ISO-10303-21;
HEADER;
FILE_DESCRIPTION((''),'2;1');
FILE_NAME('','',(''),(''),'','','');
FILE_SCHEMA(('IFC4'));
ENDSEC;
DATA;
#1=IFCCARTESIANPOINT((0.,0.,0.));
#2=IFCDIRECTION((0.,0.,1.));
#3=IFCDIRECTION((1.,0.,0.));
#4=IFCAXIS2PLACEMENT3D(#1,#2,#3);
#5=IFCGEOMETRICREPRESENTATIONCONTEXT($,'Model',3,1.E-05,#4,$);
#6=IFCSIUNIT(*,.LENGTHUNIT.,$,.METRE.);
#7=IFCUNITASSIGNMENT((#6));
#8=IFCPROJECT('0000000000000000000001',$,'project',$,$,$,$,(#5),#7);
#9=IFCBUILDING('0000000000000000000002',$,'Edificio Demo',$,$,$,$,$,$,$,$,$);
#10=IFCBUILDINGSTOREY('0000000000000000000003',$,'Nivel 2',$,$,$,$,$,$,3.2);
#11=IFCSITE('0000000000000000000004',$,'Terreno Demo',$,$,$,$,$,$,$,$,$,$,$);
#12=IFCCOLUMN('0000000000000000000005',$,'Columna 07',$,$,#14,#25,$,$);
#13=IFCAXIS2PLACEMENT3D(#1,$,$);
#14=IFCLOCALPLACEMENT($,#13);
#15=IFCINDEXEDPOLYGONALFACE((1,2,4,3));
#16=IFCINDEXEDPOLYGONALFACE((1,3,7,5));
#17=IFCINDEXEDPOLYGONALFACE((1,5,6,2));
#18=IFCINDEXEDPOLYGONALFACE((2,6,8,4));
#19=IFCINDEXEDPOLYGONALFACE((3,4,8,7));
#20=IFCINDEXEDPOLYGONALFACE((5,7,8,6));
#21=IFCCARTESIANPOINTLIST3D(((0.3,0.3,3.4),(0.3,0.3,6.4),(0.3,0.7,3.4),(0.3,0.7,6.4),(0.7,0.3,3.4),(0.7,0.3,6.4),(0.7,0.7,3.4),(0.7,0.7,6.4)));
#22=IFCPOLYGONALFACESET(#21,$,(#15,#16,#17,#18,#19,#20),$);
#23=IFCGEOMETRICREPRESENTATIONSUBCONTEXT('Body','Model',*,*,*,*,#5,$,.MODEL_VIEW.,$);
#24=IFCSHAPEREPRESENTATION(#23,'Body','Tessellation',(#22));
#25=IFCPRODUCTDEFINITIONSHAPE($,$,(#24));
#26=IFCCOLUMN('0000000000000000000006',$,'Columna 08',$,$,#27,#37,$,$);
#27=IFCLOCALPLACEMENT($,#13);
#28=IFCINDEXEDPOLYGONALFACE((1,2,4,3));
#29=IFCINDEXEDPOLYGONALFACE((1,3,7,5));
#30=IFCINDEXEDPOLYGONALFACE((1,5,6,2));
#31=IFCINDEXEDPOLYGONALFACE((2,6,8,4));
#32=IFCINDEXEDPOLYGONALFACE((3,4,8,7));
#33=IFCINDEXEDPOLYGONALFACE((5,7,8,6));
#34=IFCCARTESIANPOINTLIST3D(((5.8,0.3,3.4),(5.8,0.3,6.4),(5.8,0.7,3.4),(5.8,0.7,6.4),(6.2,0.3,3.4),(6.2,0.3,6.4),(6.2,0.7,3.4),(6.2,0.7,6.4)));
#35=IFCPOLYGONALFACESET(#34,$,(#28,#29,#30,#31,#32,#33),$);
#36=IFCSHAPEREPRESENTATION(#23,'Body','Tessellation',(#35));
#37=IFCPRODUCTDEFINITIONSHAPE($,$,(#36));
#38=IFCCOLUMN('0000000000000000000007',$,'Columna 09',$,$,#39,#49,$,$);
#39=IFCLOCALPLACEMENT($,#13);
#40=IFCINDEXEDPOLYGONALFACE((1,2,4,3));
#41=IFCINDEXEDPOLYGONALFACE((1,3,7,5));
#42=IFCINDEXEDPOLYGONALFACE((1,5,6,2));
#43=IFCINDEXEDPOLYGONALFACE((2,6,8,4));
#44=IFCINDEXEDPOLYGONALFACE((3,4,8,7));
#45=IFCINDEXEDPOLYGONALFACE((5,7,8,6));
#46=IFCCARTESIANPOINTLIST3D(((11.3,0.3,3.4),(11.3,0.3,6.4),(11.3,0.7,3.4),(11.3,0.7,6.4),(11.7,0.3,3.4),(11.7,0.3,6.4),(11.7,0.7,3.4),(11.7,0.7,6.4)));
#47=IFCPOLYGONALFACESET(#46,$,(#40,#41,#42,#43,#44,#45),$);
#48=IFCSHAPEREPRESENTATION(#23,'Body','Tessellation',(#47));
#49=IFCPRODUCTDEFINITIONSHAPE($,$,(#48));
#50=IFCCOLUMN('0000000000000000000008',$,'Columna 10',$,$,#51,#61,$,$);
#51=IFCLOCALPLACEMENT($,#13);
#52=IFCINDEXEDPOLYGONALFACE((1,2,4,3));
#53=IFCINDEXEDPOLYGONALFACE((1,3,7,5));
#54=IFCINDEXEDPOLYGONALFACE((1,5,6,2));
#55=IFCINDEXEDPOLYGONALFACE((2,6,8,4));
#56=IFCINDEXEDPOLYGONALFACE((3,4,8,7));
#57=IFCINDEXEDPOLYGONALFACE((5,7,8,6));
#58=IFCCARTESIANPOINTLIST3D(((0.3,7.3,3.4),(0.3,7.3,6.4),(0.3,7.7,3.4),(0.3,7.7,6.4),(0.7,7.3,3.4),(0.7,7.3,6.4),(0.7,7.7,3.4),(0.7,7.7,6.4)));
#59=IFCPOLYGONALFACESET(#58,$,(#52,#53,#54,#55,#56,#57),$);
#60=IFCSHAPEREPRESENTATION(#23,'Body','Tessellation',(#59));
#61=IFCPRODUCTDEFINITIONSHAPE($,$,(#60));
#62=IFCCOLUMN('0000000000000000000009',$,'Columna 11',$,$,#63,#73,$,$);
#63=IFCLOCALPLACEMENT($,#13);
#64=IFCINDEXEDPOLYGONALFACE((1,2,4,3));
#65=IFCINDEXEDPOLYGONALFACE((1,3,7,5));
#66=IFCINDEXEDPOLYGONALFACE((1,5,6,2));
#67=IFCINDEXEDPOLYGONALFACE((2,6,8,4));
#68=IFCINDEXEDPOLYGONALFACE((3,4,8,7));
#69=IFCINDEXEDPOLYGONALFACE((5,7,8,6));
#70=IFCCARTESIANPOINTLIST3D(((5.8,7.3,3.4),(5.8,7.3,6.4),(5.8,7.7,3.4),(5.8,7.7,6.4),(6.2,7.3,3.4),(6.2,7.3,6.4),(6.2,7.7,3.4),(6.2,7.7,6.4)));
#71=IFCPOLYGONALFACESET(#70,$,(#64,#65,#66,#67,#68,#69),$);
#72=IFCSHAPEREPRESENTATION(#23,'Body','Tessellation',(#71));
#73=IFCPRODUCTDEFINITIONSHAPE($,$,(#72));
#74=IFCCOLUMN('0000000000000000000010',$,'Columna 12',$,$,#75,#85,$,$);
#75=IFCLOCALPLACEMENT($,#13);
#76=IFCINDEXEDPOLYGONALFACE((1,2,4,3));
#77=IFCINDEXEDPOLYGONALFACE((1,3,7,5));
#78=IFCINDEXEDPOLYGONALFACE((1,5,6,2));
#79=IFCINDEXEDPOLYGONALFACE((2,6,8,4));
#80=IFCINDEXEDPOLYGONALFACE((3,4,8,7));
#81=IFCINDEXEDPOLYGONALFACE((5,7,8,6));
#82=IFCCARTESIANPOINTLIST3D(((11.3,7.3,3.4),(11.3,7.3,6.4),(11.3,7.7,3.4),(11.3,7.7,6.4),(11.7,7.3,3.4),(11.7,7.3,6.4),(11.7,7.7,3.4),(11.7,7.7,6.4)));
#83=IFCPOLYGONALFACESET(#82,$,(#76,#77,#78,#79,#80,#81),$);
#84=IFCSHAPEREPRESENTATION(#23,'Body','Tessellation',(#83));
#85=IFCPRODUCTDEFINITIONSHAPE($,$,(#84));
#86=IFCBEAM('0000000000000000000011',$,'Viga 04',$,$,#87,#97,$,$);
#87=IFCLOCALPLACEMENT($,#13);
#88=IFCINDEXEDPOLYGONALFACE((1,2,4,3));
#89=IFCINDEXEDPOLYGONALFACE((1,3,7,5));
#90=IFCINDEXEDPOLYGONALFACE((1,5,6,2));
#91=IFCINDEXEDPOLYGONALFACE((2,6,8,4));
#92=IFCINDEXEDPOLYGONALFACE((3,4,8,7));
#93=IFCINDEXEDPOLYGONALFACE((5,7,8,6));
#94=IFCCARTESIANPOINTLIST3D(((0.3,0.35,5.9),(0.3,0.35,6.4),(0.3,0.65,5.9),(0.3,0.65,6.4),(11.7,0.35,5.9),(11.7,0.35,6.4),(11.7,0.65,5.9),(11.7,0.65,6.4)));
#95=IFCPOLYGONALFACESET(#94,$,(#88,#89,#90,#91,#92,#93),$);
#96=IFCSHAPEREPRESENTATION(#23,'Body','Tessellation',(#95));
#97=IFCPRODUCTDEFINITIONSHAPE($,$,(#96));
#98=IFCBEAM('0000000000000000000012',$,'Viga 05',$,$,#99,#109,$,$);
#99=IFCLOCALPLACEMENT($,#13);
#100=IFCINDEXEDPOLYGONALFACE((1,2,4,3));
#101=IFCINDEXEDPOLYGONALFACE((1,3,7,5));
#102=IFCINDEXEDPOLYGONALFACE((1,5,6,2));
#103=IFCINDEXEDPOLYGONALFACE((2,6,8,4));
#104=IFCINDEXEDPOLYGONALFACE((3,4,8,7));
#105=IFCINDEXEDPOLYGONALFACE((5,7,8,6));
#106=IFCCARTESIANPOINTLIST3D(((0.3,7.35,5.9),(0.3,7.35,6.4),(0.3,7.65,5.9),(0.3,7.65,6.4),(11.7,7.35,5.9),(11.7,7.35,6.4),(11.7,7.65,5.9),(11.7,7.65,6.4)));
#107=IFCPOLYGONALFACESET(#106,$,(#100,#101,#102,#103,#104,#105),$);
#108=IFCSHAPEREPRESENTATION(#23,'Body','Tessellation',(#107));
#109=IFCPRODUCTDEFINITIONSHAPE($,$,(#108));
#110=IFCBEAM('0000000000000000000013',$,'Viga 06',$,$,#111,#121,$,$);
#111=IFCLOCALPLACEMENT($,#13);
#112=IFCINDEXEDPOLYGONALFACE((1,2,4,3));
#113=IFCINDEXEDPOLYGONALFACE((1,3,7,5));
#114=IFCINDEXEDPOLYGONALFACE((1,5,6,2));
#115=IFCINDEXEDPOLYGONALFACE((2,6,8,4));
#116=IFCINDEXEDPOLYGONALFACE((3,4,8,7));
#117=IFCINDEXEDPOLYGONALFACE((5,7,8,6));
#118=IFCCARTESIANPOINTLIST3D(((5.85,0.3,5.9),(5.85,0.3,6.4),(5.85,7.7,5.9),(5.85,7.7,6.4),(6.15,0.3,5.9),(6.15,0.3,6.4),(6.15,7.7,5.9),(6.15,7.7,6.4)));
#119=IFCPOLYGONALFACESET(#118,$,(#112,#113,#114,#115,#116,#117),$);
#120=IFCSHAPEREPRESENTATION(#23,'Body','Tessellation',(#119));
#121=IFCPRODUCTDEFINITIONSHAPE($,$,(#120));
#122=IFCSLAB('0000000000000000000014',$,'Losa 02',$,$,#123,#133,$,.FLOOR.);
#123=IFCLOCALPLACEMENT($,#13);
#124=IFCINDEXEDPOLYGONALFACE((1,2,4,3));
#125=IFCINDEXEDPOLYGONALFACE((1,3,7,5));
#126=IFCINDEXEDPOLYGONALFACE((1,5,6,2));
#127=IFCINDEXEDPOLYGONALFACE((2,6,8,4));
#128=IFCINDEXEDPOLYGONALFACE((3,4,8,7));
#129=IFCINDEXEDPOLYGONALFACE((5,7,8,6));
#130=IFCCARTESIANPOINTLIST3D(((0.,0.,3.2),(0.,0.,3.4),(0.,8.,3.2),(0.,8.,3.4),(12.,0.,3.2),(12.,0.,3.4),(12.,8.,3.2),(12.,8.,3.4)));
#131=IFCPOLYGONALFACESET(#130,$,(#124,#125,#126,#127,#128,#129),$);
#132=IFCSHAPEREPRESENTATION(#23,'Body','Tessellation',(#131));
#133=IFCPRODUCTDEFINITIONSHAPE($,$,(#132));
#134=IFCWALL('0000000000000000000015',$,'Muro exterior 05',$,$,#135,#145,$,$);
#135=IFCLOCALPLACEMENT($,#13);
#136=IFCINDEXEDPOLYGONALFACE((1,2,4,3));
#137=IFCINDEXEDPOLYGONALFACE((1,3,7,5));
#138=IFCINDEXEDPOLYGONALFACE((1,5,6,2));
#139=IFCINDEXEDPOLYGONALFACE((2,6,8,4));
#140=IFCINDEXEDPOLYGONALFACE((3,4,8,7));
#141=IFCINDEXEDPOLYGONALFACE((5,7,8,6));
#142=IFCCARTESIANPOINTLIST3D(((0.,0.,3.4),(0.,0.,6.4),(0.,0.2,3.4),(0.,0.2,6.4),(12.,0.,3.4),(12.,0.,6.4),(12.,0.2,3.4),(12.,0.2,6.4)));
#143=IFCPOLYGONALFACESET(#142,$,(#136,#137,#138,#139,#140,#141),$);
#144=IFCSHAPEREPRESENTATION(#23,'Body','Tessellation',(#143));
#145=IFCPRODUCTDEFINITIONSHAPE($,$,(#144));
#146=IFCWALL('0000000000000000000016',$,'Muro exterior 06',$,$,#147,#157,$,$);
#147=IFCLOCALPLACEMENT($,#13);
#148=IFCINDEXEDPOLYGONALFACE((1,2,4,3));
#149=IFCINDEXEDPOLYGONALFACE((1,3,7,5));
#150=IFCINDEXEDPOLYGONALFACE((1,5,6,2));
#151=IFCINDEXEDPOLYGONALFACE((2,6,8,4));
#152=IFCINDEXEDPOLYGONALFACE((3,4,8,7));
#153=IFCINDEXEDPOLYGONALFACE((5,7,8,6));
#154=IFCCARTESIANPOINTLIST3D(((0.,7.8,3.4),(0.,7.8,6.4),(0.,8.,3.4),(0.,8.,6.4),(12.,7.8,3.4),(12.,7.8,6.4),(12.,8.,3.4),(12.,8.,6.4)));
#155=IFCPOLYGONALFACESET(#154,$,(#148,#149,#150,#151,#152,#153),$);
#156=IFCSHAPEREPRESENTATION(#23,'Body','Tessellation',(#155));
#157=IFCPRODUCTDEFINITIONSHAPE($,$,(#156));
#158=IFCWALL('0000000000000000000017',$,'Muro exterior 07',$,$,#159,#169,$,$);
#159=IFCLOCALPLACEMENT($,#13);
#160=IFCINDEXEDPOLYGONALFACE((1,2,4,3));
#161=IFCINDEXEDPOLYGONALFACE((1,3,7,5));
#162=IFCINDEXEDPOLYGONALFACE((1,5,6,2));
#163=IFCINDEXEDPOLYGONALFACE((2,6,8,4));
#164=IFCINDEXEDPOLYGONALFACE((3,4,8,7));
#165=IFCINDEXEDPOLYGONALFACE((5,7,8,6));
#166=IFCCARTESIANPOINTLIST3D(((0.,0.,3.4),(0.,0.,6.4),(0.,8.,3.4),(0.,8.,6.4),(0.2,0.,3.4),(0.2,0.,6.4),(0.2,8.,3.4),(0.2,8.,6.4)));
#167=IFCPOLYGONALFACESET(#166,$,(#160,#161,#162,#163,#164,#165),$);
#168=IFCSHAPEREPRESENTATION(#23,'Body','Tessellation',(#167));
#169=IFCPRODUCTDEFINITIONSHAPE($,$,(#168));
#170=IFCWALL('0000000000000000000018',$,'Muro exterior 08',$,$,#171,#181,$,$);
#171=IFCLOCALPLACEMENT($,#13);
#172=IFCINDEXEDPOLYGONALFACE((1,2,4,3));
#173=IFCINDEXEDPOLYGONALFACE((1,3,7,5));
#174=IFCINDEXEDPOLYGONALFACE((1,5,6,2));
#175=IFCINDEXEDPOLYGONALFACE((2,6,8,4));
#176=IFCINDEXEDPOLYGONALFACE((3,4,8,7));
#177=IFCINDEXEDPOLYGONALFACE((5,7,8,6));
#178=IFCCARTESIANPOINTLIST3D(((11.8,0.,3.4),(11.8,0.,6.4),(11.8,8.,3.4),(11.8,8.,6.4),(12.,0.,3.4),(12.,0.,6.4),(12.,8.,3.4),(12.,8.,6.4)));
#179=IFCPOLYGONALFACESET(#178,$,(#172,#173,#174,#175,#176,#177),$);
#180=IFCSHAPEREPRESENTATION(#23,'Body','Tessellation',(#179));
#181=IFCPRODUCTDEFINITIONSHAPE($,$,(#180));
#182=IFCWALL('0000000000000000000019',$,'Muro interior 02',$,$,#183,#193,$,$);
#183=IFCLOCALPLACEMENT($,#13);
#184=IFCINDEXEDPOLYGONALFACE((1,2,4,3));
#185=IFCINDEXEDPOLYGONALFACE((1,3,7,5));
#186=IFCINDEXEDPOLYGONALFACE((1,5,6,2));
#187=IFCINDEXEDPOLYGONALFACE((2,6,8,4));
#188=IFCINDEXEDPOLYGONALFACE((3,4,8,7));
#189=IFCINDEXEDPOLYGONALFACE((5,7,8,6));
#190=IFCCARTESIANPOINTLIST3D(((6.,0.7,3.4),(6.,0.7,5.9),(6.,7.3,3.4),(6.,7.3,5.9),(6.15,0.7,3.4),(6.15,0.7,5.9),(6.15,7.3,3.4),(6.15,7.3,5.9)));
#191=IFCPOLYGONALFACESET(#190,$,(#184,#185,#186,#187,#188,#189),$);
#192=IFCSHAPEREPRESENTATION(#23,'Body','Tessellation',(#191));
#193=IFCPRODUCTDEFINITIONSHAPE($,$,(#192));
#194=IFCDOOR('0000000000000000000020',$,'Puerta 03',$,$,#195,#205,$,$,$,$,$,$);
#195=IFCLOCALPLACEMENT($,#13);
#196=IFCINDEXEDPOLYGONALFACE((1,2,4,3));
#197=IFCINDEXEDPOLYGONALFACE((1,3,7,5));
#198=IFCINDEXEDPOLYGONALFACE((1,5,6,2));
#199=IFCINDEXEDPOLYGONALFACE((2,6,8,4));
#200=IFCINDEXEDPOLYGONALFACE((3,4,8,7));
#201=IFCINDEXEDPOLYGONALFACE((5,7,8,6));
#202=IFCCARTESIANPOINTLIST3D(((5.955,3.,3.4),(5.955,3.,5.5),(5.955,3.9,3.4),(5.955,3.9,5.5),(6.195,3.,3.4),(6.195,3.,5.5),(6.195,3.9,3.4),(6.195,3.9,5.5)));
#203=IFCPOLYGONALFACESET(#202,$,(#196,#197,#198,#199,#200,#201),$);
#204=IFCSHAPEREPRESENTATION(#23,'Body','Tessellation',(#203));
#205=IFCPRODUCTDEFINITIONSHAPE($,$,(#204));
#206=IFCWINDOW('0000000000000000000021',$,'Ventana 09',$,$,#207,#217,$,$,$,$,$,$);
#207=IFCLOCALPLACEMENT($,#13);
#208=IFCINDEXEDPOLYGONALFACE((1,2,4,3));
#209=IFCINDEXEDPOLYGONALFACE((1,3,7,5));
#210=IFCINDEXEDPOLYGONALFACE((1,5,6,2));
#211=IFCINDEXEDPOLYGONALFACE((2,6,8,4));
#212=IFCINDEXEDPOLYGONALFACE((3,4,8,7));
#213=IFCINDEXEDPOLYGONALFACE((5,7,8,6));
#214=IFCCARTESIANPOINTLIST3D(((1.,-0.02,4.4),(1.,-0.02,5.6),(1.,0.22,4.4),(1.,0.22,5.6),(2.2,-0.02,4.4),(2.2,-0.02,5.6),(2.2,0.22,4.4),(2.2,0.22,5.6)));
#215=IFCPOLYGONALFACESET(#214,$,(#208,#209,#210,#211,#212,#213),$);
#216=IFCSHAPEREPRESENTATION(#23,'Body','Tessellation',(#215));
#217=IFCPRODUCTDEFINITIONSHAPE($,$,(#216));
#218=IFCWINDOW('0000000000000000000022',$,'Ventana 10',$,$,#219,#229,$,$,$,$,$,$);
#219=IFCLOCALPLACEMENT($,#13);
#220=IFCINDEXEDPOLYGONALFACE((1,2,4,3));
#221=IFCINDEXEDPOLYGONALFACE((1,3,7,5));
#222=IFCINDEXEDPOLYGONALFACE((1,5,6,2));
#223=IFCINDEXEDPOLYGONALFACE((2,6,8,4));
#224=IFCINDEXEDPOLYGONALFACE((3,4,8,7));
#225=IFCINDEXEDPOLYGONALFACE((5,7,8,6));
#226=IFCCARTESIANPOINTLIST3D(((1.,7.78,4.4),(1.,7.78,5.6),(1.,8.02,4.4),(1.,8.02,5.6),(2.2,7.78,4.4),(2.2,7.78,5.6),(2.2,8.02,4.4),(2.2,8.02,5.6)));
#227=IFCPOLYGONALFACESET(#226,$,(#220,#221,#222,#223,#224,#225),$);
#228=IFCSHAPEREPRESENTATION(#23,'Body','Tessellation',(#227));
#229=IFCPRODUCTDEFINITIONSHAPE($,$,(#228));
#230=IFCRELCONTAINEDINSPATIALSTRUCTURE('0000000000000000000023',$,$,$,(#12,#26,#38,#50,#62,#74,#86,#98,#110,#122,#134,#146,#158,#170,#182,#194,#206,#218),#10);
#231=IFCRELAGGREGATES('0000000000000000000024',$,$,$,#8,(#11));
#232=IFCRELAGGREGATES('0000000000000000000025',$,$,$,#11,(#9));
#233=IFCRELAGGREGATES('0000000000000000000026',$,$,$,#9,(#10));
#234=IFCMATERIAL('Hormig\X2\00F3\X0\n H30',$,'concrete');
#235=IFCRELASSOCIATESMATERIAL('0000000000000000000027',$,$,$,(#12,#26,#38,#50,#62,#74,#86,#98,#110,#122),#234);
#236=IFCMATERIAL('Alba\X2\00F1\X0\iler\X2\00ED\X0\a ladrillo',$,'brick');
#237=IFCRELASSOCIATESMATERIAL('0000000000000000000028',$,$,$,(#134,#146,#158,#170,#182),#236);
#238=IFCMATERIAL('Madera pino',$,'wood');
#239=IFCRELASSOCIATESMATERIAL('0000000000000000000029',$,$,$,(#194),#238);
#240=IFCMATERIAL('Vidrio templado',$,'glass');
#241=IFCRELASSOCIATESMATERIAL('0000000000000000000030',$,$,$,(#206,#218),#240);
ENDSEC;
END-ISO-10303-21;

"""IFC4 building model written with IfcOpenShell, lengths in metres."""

from ifc_helpers import new_model, si_unit, frame, frame_2d, origin_with_axes, place, context, subcontext, project, spatial, rectangle, extrude, material, element, save


model = new_model("IFC4")

# Units and contexts
model_context = context("Model", 3, precision=1e-05, world=origin_with_axes())
body_context = subcontext(model_context, "Body", "Model", "MODEL_VIEW")
ifc_project = project(units=[si_unit("LENGTHUNIT", "METRE")], contexts=[model_context])

# Site, building, storey
site = spatial("IfcSite", under=ifc_project, Name="Terreno Demo")
building = spatial("IfcBuilding", under=site, Name="Edificio Demo")
storey = spatial("IfcBuildingStorey", under=building, Name="Nivel 2", Elevation=3.2)

# Columns
ifc_material_1 = material(Name="Hormigón H30", Category="concrete")
for number, where, z_axis, x_axis, name in (
    (1, (0.3, 0.3, 3.4), (0.0, 0.0, 1.0), (1.0, 0.0, 0.0), "Columna 07"),
    (2, (5.8, 0.3, 3.4), (0.0, 0.0, 1.0), (1.0, 0.0, 0.0), "Columna 08"),
    (3, (11.3, 0.3, 3.4), (0.0, 0.0, 1.0), (1.0, 0.0, 0.0), "Columna 09"),
    (4, (0.3, 7.3, 3.4), (0.0, 0.0, 1.0), (1.0, 0.0, 0.0), "Columna 10"),
    (5, (5.8, 7.3, 3.4), (0.0, 0.0, 1.0), (1.0, 0.0, 0.0), "Columna 11"),
    (6, (11.3, 7.3, 3.4), (0.0, 0.0, 1.0), (1.0, 0.0, 0.0), "Columna 12"),
):
    element("IfcColumn", number, at=place(None, frame(where, z_axis=z_axis, x_axis=x_axis)), inside=storey, material=ifc_material_1, Name=name, context=body_context, shape_type="SweptSolid", body=[
        extrude(rectangle(XDim=0.4, YDim=0.4, at=frame_2d((0.2, 0.2))), origin_with_axes(), (0.0, 0.0, 1.0), 3.0),
    ])

# Beams
for number, where, z_axis, x_axis, name in (
    (7, (0.3, 0.35, 5.9), (0.0, 0.0, 1.0), (1.0, 0.0, 0.0), "Viga 04"),
    (8, (0.3, 7.35, 5.9), (0.0, 0.0, 1.0), (1.0, 0.0, 0.0), "Viga 05"),
):
    element("IfcBeam", number, at=place(None, frame(where, z_axis=z_axis, x_axis=x_axis)), inside=storey, material=ifc_material_1, Name=name, context=body_context, shape_type="SweptSolid", body=[
        extrude(rectangle(XDim=11.4, YDim=0.3, at=frame_2d((5.7, 0.15))), origin_with_axes(), (0.0, 0.0, 1.0), 0.5),
    ])
beam_placement = place(None, frame((5.85, 0.3, 5.9), z_axis=(0.0, 0.0, 1.0), x_axis=(1.0, 0.0, 0.0)))
element("IfcBeam", 9, at=beam_placement, inside=storey, material=ifc_material_1, Name="Viga 06", context=body_context, shape_type="SweptSolid", body=[
    extrude(rectangle(XDim=0.3, YDim=7.4, at=frame_2d((0.15, 3.7))), origin_with_axes(), (0.0, 0.0, 1.0), 0.5),
])

# Slab
slab_placement = place(None, frame((0.0, 0.0, 3.2), z_axis=(0.0, 0.0, 1.0), x_axis=(1.0, 0.0, 0.0)))
element("IfcSlab", 10, at=slab_placement, inside=storey, material=ifc_material_1, Name="Losa 02", PredefinedType="FLOOR", context=body_context, shape_type="SweptSolid", body=[
    extrude(rectangle(XDim=12.0, YDim=8.0, at=frame_2d((6.0, 4.0))), origin_with_axes(), (0.0, 0.0, 1.0), 0.2),
])

# Walls
ifc_material_2 = material(Name="Albañilería ladrillo", Category="brick")
for number, where, z_axis, x_axis, name in (
    (11, (0.0, 0.0, 3.4), (0.0, 0.0, 1.0), (1.0, 0.0, 0.0), "Muro exterior 05"),
    (12, (0.0, 7.8, 3.4), (0.0, 0.0, 1.0), (1.0, 0.0, 0.0), "Muro exterior 06"),
):
    element("IfcWall", number, at=place(None, frame(where, z_axis=z_axis, x_axis=x_axis)), inside=storey, material=ifc_material_2, Name=name, context=body_context, shape_type="SweptSolid", body=[
        extrude(rectangle(XDim=12.0, YDim=0.2, at=frame_2d((6.0, 0.1))), origin_with_axes(), (0.0, 0.0, 1.0), 3.0),
    ])
for number, where, z_axis, x_axis, name in (
    (13, (0.0, 0.0, 3.4), (0.0, 0.0, 1.0), (1.0, 0.0, 0.0), "Muro exterior 07"),
    (14, (11.8, 0.0, 3.4), (0.0, 0.0, 1.0), (1.0, 0.0, 0.0), "Muro exterior 08"),
):
    element("IfcWall", number, at=place(None, frame(where, z_axis=z_axis, x_axis=x_axis)), inside=storey, material=ifc_material_2, Name=name, context=body_context, shape_type="SweptSolid", body=[
        extrude(rectangle(XDim=0.2, YDim=8.0, at=frame_2d((0.1, 4.0))), origin_with_axes(), (0.0, 0.0, 1.0), 3.0),
    ])
wall_placement = place(None, frame((6.0, 0.7, 3.4), z_axis=(0.0, 0.0, 1.0), x_axis=(1.0, 0.0, 0.0)))
element("IfcWall", 15, at=wall_placement, inside=storey, material=ifc_material_2, Name="Muro interior 02", context=body_context, shape_type="SweptSolid", body=[
    extrude(rectangle(XDim=0.15, YDim=6.6, at=frame_2d((0.075, 3.3))), origin_with_axes(), (0.0, 0.0, 1.0), 2.5),
])

# Door
ifc_material_3 = material(Name="Madera pino", Category="wood")
door_placement = place(None, frame((6.195, 3.0, 3.4), z_axis=(0.0, 0.0, 1.0), x_axis=(0.0, 1.0, 0.0)))
element("IfcDoor", 16, at=door_placement, inside=storey, material=ifc_material_3, Name="Puerta 03", context=body_context, shape_type="SweptSolid", body=[
    extrude(rectangle(XDim=0.9, YDim=0.24, at=frame_2d((0.45, 0.12))), origin_with_axes(), (0.0, 0.0, 1.0), 2.1),
])

# Windows
ifc_material_4 = material(Name="Vidrio templado", Category="glass")
for number, where, z_axis, x_axis, name in (
    (17, (1.0, -0.02, 4.4), (0.0, 0.0, 1.0), (1.0, 0.0, 0.0), "Ventana 09"),
    (18, (1.0, 7.78, 4.4), (0.0, 0.0, 1.0), (1.0, 0.0, 0.0), "Ventana 10"),
):
    element("IfcWindow", number, at=place(None, frame(where, z_axis=z_axis, x_axis=x_axis)), inside=storey, material=ifc_material_4, Name=name, context=body_context, shape_type="SweptSolid", body=[
        extrude(rectangle(XDim=1.2, YDim=0.24, at=frame_2d((0.6, 0.12))), origin_with_axes(), (0.0, 0.0, 1.0), 1.2),
    ])

save(model, "model.ifc")
